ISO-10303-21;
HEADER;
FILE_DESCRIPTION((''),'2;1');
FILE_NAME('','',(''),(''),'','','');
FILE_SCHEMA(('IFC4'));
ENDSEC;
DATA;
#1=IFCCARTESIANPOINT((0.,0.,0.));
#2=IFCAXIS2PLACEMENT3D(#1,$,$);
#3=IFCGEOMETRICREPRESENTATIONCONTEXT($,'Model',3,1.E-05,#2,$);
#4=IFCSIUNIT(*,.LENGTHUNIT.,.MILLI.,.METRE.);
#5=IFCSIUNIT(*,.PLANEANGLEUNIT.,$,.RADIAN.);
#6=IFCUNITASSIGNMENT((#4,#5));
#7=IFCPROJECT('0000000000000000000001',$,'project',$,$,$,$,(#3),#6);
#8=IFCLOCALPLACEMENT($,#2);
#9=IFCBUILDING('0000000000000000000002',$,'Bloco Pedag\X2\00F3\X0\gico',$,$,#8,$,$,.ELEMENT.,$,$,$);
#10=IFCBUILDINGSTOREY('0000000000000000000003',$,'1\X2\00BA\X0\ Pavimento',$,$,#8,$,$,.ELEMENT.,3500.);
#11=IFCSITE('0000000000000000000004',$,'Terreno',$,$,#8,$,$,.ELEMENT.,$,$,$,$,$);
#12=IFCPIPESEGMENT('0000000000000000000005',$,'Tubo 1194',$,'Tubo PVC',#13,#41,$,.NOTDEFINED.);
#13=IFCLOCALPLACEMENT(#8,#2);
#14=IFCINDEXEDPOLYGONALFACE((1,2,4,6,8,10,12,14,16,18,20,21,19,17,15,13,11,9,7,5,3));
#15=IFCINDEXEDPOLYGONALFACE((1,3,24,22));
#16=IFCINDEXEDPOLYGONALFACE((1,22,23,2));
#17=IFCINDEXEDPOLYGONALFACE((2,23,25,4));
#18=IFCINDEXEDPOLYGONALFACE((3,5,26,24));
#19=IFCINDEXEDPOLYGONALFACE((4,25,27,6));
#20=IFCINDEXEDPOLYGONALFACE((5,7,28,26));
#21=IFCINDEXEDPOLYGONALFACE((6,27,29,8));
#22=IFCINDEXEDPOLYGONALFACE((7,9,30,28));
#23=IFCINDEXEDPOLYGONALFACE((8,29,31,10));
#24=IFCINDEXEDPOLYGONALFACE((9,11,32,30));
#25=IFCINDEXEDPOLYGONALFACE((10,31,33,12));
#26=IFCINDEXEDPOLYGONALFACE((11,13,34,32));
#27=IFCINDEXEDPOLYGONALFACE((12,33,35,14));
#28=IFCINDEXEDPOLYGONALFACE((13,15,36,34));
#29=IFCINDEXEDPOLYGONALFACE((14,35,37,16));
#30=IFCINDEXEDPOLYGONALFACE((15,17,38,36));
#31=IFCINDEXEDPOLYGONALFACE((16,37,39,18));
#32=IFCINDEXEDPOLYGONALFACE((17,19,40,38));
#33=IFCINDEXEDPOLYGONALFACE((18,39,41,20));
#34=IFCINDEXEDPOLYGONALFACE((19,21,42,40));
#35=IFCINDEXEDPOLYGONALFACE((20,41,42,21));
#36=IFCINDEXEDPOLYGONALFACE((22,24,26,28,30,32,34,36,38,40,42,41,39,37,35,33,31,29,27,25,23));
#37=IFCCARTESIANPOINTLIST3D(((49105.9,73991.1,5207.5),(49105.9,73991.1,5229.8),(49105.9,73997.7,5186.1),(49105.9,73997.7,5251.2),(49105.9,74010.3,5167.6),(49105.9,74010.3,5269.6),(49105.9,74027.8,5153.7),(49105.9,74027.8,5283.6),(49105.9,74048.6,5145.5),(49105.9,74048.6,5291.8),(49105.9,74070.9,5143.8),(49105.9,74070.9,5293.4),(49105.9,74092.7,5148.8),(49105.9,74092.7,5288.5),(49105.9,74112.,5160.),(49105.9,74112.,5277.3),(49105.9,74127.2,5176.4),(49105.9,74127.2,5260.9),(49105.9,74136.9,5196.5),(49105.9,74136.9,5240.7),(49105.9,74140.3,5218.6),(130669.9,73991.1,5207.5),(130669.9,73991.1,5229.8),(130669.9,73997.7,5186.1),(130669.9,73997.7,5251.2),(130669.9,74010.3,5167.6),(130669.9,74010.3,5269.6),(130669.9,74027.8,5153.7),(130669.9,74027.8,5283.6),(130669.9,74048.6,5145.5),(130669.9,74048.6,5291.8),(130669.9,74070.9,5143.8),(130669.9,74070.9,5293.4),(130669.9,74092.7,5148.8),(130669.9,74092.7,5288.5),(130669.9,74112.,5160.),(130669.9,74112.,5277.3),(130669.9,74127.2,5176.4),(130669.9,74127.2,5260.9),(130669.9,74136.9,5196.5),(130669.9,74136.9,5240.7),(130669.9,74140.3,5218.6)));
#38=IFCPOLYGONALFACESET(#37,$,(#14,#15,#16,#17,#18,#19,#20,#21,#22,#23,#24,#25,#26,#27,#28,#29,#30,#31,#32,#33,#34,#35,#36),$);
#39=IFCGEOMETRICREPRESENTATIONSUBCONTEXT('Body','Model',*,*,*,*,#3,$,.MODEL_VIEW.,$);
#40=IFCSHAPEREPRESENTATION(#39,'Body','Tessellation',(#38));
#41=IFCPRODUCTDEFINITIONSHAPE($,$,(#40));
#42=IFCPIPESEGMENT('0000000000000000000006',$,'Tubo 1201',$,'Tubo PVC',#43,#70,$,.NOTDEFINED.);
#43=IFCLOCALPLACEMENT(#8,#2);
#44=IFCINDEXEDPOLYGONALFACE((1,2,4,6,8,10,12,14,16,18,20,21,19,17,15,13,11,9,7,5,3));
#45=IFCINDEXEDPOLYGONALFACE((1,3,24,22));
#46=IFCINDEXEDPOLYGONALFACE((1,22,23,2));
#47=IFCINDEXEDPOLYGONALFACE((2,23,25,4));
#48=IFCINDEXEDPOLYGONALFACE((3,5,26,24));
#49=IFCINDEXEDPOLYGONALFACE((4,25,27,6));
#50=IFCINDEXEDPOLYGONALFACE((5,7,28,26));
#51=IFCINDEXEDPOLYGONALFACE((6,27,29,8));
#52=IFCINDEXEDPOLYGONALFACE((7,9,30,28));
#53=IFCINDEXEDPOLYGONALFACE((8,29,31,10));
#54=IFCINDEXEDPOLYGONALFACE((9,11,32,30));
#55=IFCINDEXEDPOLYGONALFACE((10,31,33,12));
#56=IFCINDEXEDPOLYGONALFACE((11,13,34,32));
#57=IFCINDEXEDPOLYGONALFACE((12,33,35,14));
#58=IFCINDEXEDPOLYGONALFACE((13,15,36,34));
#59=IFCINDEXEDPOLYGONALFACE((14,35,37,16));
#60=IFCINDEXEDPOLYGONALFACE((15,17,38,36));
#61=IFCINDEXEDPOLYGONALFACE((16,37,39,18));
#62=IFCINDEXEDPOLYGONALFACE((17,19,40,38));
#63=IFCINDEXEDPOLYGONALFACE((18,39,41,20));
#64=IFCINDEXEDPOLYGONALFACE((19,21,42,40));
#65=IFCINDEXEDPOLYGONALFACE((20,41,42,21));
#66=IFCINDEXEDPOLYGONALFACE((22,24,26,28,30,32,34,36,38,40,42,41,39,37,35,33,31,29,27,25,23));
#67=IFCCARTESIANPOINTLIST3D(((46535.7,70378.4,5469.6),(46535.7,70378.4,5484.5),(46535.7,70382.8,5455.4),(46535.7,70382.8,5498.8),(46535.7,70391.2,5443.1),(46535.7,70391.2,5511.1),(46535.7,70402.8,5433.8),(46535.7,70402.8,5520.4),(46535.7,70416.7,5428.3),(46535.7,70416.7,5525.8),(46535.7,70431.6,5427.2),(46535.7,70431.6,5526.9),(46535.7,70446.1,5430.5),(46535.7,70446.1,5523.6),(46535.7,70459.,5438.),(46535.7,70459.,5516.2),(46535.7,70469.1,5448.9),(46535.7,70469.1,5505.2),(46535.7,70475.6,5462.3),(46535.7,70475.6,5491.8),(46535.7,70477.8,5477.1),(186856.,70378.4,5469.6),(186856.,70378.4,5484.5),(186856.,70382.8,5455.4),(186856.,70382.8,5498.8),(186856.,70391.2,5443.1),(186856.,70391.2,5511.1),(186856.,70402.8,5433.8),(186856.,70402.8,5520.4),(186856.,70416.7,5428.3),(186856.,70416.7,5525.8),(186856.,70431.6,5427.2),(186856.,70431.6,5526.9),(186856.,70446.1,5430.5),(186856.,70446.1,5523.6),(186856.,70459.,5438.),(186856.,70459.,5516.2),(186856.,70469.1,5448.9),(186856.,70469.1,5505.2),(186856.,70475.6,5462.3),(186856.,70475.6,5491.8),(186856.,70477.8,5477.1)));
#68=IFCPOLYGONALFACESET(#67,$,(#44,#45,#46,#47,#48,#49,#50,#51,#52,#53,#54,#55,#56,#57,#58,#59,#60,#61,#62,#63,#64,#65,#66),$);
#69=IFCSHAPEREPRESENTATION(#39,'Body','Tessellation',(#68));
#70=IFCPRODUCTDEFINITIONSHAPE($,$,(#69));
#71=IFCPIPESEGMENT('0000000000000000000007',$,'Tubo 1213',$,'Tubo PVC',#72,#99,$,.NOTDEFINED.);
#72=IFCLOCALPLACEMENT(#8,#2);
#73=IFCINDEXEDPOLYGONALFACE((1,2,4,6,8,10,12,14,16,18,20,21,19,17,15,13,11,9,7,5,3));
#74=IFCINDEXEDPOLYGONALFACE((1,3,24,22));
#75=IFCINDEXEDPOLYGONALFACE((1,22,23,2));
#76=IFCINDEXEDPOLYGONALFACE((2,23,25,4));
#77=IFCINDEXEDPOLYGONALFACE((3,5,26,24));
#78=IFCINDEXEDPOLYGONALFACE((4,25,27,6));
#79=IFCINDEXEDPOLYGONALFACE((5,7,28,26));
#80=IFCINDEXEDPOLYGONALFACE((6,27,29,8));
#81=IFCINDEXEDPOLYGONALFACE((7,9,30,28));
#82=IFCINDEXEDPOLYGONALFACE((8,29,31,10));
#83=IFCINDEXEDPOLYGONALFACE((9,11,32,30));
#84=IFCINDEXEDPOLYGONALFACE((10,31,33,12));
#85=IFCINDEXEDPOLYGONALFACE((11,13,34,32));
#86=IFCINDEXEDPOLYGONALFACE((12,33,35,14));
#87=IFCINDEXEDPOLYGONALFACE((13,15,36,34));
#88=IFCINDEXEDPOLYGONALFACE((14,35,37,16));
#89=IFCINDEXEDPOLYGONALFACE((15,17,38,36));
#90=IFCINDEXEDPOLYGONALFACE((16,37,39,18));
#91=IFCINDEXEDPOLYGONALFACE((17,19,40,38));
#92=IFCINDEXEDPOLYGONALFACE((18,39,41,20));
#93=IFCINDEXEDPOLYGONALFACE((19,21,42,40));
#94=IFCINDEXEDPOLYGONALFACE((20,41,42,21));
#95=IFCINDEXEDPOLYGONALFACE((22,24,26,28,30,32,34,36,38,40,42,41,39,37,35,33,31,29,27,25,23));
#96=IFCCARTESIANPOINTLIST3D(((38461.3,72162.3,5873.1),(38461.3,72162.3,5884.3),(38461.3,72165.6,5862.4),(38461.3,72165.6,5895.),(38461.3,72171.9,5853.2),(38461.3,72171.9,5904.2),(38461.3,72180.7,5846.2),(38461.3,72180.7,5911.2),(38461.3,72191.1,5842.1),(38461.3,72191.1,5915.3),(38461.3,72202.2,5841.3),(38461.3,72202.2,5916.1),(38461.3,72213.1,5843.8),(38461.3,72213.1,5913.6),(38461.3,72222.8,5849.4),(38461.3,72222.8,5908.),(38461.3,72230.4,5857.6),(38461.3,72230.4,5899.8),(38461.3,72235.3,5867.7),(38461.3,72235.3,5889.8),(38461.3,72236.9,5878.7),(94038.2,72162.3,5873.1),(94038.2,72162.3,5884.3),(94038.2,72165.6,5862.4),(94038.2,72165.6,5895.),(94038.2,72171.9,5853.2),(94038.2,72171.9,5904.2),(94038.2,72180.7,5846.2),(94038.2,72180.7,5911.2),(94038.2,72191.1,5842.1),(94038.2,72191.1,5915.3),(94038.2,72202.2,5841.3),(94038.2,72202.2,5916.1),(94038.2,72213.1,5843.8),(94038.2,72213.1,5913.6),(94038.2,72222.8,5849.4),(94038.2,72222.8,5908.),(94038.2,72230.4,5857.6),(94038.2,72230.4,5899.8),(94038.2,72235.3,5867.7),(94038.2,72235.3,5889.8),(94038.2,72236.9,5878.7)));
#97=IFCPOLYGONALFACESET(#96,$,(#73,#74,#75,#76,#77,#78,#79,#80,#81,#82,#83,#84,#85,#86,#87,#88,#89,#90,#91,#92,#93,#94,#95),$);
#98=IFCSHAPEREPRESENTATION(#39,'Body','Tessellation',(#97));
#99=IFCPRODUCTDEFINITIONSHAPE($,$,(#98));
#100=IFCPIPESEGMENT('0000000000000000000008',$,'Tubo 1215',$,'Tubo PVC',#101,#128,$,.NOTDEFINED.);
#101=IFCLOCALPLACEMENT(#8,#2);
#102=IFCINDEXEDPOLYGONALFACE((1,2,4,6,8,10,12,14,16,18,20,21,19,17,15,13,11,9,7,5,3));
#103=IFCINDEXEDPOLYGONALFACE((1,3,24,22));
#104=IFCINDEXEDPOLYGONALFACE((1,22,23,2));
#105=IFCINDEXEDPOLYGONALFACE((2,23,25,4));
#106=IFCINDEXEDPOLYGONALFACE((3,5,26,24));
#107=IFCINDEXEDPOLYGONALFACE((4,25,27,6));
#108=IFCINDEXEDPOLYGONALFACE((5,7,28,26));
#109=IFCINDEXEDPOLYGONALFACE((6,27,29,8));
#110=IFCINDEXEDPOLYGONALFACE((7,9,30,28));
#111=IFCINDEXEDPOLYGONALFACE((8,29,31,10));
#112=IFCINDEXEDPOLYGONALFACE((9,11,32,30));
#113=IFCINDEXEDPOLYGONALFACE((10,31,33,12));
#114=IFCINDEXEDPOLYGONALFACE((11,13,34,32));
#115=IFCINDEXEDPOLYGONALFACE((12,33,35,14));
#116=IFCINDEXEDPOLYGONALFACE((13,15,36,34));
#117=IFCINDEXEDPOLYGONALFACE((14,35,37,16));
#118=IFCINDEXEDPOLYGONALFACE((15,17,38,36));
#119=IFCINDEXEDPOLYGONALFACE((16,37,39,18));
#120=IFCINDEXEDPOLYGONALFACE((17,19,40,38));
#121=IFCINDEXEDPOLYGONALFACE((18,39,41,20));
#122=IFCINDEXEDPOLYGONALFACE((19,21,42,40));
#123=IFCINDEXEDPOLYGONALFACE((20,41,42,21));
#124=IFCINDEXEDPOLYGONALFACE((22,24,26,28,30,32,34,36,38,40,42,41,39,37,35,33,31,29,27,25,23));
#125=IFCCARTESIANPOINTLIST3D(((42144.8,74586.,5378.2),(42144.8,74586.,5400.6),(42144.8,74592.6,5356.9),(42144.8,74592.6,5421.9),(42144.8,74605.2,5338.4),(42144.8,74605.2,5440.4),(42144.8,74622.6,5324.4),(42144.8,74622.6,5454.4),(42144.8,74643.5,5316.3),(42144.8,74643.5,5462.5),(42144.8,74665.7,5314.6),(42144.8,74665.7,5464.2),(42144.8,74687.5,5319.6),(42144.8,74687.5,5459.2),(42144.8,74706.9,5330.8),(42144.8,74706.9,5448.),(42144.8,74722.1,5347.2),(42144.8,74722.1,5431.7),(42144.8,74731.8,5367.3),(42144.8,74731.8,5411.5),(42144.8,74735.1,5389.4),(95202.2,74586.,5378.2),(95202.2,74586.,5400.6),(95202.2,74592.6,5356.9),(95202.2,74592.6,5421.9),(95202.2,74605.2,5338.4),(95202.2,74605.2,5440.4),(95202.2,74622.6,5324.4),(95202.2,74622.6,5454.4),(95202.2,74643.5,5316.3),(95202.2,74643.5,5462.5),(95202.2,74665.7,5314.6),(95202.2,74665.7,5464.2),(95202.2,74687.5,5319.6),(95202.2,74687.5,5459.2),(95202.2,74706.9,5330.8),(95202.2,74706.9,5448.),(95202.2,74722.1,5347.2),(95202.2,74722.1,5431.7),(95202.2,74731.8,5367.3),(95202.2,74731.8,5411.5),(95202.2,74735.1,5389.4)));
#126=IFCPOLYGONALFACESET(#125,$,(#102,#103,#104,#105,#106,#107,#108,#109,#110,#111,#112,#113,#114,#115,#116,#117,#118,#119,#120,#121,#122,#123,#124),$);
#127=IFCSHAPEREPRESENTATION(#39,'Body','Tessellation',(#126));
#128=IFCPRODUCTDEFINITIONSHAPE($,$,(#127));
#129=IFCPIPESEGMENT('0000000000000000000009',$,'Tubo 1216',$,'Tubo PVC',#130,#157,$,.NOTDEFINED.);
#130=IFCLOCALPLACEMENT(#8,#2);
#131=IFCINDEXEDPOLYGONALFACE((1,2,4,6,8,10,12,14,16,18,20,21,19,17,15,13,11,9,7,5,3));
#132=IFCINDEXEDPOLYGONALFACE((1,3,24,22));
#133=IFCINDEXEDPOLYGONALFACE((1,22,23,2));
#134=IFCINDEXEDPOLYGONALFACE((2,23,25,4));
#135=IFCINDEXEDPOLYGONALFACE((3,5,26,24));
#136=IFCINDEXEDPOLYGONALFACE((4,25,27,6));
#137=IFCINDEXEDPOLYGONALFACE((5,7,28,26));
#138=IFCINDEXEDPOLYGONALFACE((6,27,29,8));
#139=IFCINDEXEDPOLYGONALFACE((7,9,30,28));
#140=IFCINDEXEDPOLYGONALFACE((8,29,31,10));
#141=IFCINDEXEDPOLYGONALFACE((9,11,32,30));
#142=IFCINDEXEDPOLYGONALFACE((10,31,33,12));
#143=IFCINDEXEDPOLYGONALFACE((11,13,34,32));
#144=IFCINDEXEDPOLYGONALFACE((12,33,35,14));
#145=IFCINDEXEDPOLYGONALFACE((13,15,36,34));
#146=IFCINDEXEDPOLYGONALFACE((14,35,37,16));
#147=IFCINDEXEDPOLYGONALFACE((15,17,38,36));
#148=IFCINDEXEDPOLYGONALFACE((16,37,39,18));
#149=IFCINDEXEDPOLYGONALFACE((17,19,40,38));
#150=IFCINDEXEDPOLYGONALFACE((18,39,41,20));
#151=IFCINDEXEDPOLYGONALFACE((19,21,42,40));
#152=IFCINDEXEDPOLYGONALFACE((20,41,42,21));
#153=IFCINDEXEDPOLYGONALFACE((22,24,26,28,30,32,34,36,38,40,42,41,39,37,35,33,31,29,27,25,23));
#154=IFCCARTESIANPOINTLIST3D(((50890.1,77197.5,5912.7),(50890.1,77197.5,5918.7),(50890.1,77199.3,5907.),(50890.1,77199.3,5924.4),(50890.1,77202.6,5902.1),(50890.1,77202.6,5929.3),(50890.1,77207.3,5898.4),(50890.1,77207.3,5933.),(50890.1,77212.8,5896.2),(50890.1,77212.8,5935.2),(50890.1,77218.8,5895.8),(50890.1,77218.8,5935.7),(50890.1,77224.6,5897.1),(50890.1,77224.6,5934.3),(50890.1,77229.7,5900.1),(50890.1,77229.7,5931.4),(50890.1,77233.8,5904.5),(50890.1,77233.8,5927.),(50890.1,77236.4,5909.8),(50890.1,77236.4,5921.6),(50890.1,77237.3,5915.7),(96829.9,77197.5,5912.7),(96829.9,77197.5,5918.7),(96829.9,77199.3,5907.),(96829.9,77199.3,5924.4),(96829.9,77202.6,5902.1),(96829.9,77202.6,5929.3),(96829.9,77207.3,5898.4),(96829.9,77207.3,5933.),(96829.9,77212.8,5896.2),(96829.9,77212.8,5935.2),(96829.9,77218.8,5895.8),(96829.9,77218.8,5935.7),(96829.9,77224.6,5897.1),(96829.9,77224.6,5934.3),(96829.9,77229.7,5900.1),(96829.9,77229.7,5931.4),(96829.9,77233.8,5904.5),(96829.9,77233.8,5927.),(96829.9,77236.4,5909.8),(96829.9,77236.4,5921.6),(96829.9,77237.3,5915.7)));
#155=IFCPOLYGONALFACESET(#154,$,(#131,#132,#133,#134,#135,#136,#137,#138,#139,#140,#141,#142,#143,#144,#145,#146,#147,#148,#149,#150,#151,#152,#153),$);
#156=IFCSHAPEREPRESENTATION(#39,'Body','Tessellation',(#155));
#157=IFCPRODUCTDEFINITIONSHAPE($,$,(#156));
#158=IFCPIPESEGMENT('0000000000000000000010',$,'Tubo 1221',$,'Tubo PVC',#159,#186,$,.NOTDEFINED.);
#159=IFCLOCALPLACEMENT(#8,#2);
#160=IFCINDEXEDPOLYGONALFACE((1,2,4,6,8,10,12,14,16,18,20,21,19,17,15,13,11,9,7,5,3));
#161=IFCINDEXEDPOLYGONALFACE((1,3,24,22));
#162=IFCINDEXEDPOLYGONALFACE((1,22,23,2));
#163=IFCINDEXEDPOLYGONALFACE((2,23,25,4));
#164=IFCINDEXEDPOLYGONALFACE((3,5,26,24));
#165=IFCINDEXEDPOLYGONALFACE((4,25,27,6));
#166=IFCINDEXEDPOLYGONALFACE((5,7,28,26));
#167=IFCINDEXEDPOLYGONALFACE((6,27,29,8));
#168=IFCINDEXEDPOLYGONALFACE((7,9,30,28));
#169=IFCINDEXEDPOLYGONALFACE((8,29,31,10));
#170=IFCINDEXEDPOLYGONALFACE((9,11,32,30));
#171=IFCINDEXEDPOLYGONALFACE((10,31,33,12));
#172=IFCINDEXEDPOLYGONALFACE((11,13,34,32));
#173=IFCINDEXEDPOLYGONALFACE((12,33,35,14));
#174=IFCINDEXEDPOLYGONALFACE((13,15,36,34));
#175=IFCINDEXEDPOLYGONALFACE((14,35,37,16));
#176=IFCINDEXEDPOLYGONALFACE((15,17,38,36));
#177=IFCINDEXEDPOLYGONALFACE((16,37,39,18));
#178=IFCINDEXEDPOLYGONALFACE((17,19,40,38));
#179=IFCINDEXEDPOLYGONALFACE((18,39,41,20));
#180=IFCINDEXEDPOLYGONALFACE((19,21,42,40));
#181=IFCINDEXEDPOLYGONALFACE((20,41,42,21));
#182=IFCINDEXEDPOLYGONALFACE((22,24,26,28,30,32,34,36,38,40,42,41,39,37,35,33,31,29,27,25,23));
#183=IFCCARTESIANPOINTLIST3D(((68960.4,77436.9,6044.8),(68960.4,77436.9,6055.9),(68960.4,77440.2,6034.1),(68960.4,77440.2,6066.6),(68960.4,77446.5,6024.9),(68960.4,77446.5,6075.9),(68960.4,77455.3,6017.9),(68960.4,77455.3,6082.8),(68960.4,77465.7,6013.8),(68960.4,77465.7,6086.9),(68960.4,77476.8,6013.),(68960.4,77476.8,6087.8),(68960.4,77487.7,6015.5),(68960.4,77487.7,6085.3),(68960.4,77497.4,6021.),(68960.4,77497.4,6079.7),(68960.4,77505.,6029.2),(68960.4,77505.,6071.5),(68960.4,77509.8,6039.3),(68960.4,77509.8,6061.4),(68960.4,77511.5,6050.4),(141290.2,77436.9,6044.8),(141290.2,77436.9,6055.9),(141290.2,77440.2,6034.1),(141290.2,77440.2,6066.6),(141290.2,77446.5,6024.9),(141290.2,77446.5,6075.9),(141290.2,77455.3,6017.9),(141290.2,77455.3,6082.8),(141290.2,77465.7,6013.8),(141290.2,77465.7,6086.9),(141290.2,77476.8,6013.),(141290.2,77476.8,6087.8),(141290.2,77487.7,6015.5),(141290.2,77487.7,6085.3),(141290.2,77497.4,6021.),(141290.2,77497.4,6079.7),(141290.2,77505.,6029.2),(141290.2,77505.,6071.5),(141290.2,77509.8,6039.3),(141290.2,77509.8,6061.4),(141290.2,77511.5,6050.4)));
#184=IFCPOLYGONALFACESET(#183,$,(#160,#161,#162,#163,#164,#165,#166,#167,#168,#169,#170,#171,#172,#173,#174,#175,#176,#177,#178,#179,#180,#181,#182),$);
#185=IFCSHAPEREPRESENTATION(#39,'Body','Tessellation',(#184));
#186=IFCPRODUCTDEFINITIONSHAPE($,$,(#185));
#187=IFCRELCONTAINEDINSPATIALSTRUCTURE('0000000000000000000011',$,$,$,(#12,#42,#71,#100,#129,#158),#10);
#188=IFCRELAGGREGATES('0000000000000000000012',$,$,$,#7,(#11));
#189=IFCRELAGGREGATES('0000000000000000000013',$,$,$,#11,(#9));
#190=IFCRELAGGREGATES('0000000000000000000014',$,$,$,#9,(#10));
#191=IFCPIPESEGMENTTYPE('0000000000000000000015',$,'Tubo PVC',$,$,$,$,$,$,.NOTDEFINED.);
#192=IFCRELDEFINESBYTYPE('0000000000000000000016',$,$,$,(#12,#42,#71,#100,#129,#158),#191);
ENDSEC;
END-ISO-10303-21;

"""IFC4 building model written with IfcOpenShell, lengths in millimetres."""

from ifc_helpers import new_model, si_unit, frame, origin, origin_2d, place, context, subcontext, project, spatial, circle, extrude, type_object, element, save


model = new_model("IFC4")

# Units and contexts
model_context = context("Model", 3, precision=1e-05, world=origin())
body_context = subcontext(model_context, "Body", "Model", "MODEL_VIEW")
ifc_project = project(units=[si_unit("LENGTHUNIT", "METRE", prefix="MILLI"), si_unit("PLANEANGLEUNIT", "RADIAN")], contexts=[model_context])

# Site, building, storey
placement = place(None, origin())
site = spatial("IfcSite", under=ifc_project, at=placement, Name="Terreno", CompositionType="ELEMENT")
building = spatial("IfcBuilding", under=site, at=placement, Name="Bloco Pedagógico", CompositionType="ELEMENT")
storey = spatial("IfcBuildingStorey", under=building, at=placement, Name="1º Pavimento", CompositionType="ELEMENT", Elevation=3500.0)

# Pipe segments
pipe_segment_type = type_object("IfcPipeSegmentType", Name="Tubo PVC", PredefinedType="NOTDEFINED")
pipe_segment_1_placement = place(None, frame((49105.9, 74065.3, 5218.6), z_axis=(1.0, 0.0, 0.0), x_axis=(0.0, 1.0, 0.0)))
element("IfcPipeSegment", 1, at=pipe_segment_1_placement, inside=storey, type_object=pipe_segment_type, Name="Tubo 1194", ObjectType="Tubo PVC", PredefinedType="NOTDEFINED", context=body_context, shape_type="SweptSolid", body=[
    extrude(circle(Radius=75.0, at=origin_2d()), None, (0.0, 0.0, 1.0), 81564.0),
])
pipe_segment_2_placement = place(None, frame((46535.7, 70427.8, 5477.1), z_axis=(1.0, 0.0, 0.0), x_axis=(0.0, 1.0, 0.0)))
element("IfcPipeSegment", 2, at=pipe_segment_2_placement, inside=storey, type_object=pipe_segment_type, Name="Tubo 1201", ObjectType="Tubo PVC", PredefinedType="NOTDEFINED", context=body_context, shape_type="SweptSolid", body=[
    extrude(circle(Radius=50.0, at=origin_2d()), None, (0.0, 0.0, 1.0), 140320.4),
])
pipe_segment_3_placement = place(None, frame((38461.3, 72199.4, 5878.7), z_axis=(1.0, 0.0, 0.0), x_axis=(0.0, 1.0, 0.0)))
element("IfcPipeSegment", 3, at=pipe_segment_3_placement, inside=storey, type_object=pipe_segment_type, Name="Tubo 1213", ObjectType="Tubo PVC", PredefinedType="NOTDEFINED", context=body_context, shape_type="SweptSolid", body=[
    extrude(circle(Radius=37.5, at=origin_2d()), None, (0.0, 0.0, 1.0), 55576.8),
])
pipe_segment_4_placement = place(None, frame((42144.8, 74660.1, 5389.4), z_axis=(1.0, 0.0, 0.0), x_axis=(0.0, 1.0, 0.0)))
element("IfcPipeSegment", 4, at=pipe_segment_4_placement, inside=storey, type_object=pipe_segment_type, Name="Tubo 1215", ObjectType="Tubo PVC", PredefinedType="NOTDEFINED", context=body_context, shape_type="SweptSolid", body=[
    extrude(circle(Radius=75.0, at=origin_2d()), None, (0.0, 0.0, 1.0), 53057.4),
])
pipe_segment_5_placement = place(None, frame((50890.1, 77217.3, 5915.7), z_axis=(1.0, 0.0, 0.0), x_axis=(0.0, 1.0, 0.0)))
element("IfcPipeSegment", 5, at=pipe_segment_5_placement, inside=storey, type_object=pipe_segment_type, Name="Tubo 1216", ObjectType="Tubo PVC", PredefinedType="NOTDEFINED", context=body_context, shape_type="SweptSolid", body=[
    extrude(circle(Radius=20.0, at=origin_2d()), None, (0.0, 0.0, 1.0), 45939.7),
])
pipe_segment_6_placement = place(None, frame((68960.4, 77474.0, 6050.4), z_axis=(1.0, 0.0, 0.0), x_axis=(0.0, 1.0, 0.0)))
element("IfcPipeSegment", 6, at=pipe_segment_6_placement, inside=storey, type_object=pipe_segment_type, Name="Tubo 1221", ObjectType="Tubo PVC", PredefinedType="NOTDEFINED", context=body_context, shape_type="SweptSolid", body=[
    extrude(circle(Radius=37.5, at=origin_2d()), None, (0.0, 0.0, 1.0), 72329.9),
])

save(model, "model.ifc")
